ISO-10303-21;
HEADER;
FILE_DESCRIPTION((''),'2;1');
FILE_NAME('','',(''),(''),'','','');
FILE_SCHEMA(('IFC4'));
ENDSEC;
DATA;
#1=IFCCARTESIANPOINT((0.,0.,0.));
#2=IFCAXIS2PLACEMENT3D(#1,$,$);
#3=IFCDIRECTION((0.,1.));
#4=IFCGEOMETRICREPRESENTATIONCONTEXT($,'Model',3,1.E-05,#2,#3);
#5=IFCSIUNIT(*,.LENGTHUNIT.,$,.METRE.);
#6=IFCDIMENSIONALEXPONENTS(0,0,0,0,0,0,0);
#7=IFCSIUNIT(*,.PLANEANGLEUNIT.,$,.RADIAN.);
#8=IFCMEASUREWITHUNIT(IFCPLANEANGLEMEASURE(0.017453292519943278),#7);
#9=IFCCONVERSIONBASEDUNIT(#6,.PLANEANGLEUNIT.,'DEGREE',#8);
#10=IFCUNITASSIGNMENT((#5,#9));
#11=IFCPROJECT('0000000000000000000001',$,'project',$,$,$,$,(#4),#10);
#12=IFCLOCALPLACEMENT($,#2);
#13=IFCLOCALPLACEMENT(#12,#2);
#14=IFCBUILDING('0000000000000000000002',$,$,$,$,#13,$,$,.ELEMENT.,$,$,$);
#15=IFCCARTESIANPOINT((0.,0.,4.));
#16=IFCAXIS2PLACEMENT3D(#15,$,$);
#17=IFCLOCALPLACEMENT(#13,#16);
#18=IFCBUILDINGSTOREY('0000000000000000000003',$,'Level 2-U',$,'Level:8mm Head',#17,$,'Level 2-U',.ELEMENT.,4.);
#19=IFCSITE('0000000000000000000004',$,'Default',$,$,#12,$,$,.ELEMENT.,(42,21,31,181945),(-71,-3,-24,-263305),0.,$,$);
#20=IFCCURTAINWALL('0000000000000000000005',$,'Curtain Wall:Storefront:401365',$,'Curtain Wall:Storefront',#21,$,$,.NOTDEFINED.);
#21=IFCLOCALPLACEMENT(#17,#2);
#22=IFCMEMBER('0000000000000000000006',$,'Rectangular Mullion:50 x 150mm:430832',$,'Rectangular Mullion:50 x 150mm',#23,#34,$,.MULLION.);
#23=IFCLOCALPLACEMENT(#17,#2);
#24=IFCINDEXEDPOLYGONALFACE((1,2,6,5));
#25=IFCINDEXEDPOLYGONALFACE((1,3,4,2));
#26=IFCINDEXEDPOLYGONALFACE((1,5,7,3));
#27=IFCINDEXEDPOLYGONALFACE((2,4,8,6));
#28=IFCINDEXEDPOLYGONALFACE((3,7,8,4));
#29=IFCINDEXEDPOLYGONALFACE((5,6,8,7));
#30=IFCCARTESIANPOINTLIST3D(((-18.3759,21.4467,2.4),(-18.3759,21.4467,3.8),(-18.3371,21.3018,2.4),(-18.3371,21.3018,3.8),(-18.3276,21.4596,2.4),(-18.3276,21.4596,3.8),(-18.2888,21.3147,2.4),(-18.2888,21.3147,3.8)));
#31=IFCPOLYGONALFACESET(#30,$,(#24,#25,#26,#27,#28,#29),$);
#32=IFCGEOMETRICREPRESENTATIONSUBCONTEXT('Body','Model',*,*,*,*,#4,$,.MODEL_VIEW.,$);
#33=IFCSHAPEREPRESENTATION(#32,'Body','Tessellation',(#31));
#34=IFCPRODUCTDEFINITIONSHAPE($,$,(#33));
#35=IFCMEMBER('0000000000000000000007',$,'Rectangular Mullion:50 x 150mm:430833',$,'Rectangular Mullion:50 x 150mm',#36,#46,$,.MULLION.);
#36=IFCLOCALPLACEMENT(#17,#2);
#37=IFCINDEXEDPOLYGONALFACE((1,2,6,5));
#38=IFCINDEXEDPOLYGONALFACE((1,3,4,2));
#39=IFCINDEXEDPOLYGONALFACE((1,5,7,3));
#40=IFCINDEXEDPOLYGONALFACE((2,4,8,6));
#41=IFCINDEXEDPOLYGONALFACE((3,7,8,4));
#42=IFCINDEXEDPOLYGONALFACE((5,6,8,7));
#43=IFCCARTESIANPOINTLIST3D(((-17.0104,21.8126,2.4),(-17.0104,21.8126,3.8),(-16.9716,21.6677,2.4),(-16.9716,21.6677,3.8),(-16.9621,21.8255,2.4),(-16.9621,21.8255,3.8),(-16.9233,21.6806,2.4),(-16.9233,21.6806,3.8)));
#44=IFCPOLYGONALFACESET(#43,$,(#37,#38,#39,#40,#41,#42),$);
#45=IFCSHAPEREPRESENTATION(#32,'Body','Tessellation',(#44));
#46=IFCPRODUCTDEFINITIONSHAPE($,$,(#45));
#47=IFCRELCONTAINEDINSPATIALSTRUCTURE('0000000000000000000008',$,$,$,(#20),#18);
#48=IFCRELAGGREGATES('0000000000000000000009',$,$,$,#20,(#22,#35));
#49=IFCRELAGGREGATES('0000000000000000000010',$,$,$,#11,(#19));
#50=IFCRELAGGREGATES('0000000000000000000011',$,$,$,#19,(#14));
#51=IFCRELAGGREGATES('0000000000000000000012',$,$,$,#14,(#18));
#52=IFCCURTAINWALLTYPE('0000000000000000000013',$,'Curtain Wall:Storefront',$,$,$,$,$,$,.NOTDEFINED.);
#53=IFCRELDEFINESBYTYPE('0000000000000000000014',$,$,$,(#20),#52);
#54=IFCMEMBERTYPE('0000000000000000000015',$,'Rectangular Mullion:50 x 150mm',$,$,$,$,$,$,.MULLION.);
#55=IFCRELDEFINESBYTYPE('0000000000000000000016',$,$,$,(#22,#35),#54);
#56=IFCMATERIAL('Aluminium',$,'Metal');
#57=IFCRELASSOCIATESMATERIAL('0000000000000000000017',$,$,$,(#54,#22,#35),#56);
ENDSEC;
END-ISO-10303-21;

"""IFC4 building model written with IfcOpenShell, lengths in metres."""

from ifc_helpers import new_model, entity, si_unit, converted_unit, direction, frame, origin, place, context, subcontext, project, spatial, indexed_curve, outline, extrude, source, transform, mapped, material, type_object, type_shapes, element, aggregate, save


model = new_model("IFC4")

# Units and contexts
model_context = context("Model", 3, precision=1e-05, world=origin(), true_north=direction((0.0, 1.0)))
body_context = subcontext(model_context, "Body", "Model", "MODEL_VIEW")
ifc_project = project(units=[si_unit("LENGTHUNIT", "METRE"), converted_unit("PLANEANGLEUNIT", "DEGREE", entity("IfcPlaneAngleMeasure", 0.017453292519943278), si_unit("PLANEANGLEUNIT", "RADIAN"), dimensions=[0, 0, 0, 0, 0, 0, 0])], contexts=[model_context])

# Site, building, storey
site_placement = place(None, origin())
site = spatial("IfcSite", under=ifc_project, at=site_placement, Name="Default", CompositionType="ELEMENT", RefLatitude=(42, 21, 31, 181945), RefLongitude=(-71, -3, -24, -263305), RefElevation=0.0)
building_placement = place(site_placement, origin())
building = spatial("IfcBuilding", under=site, at=building_placement, CompositionType="ELEMENT")
storey_placement = place(building_placement, frame((0.0, 0.0, 4.0)))
storey = spatial("IfcBuildingStorey", under=building, at=storey_placement, Name="Level 2-U", ObjectType="Level:8mm Head", LongName="Level 2-U", CompositionType="ELEMENT", Elevation=4.0)

# Curtain wall, members
curtain_wall_type = type_object("IfcCurtainWallType", Name="Curtain Wall:Storefront", PredefinedType="NOTDEFINED")
curtain_wall_placement = place(storey_placement, frame((0.0, 0.0, -4.0)))
curtain_wall = element("IfcCurtainWall", 1, at=curtain_wall_placement, inside=storey, type_object=curtain_wall_type, Name="Curtain Wall:Storefront:401365", ObjectType="Curtain Wall:Storefront", PredefinedType="NOTDEFINED")
ifc_material_1 = material(Name="Aluminium", Category="Metal")
member_type_1 = type_object("IfcMemberType", Name="Rectangular Mullion:50 x 150mm", PredefinedType="MULLION", material=ifc_material_1)
shared_shape_1 = source(origin(), body_context, "Body", "SweptSolid", [
    extrude(outline(indexed_curve([(-0.025, -0.075), (0.025, -0.075), (0.025, 0.075), (-0.025, 0.075), (-0.025, -0.075)], self_intersect=False)), frame((0.0, 0.0, -1.4), z_axis=(0.0, 0.0, 1.0), x_axis=(-1.0, 0.0, 0.0)), (0.0, 0.0, 1.0), 1.4),
])
type_shapes(member_type_1, [shared_shape_1])
member_1_placement = place(curtain_wall_placement, frame((-18.3324, 21.3807, 6.4), z_axis=(0.0, 0.0, -1.0), x_axis=(0.965926, 0.258819, 0.0)))
member_1 = element("IfcMember", 2, at=member_1_placement, type_object=member_type_1, material=ifc_material_1, Name="Rectangular Mullion:50 x 150mm:430832", ObjectType="Rectangular Mullion:50 x 150mm", PredefinedType="MULLION", context=body_context, shape_type="MappedRepresentation", body=[
    mapped(shared_shape_1, transform((0.0, 0.0, 0.0), scale=1.0)),
])
member_2_placement = place(curtain_wall_placement, frame((-16.9669, 21.7466, 6.4), z_axis=(0.0, 0.0, -1.0), x_axis=(0.965926, 0.258819, 0.0)))
member_2 = element("IfcMember", 3, at=member_2_placement, type_object=member_type_1, material=ifc_material_1, Name="Rectangular Mullion:50 x 150mm:430833", ObjectType="Rectangular Mullion:50 x 150mm", PredefinedType="MULLION", context=body_context, shape_type="MappedRepresentation", body=[
    mapped(shared_shape_1, transform((0.0, 0.0, 0.0), scale=1.0)),
])
aggregate(curtain_wall, [member_1, member_2])

save(model, "model.ifc")
